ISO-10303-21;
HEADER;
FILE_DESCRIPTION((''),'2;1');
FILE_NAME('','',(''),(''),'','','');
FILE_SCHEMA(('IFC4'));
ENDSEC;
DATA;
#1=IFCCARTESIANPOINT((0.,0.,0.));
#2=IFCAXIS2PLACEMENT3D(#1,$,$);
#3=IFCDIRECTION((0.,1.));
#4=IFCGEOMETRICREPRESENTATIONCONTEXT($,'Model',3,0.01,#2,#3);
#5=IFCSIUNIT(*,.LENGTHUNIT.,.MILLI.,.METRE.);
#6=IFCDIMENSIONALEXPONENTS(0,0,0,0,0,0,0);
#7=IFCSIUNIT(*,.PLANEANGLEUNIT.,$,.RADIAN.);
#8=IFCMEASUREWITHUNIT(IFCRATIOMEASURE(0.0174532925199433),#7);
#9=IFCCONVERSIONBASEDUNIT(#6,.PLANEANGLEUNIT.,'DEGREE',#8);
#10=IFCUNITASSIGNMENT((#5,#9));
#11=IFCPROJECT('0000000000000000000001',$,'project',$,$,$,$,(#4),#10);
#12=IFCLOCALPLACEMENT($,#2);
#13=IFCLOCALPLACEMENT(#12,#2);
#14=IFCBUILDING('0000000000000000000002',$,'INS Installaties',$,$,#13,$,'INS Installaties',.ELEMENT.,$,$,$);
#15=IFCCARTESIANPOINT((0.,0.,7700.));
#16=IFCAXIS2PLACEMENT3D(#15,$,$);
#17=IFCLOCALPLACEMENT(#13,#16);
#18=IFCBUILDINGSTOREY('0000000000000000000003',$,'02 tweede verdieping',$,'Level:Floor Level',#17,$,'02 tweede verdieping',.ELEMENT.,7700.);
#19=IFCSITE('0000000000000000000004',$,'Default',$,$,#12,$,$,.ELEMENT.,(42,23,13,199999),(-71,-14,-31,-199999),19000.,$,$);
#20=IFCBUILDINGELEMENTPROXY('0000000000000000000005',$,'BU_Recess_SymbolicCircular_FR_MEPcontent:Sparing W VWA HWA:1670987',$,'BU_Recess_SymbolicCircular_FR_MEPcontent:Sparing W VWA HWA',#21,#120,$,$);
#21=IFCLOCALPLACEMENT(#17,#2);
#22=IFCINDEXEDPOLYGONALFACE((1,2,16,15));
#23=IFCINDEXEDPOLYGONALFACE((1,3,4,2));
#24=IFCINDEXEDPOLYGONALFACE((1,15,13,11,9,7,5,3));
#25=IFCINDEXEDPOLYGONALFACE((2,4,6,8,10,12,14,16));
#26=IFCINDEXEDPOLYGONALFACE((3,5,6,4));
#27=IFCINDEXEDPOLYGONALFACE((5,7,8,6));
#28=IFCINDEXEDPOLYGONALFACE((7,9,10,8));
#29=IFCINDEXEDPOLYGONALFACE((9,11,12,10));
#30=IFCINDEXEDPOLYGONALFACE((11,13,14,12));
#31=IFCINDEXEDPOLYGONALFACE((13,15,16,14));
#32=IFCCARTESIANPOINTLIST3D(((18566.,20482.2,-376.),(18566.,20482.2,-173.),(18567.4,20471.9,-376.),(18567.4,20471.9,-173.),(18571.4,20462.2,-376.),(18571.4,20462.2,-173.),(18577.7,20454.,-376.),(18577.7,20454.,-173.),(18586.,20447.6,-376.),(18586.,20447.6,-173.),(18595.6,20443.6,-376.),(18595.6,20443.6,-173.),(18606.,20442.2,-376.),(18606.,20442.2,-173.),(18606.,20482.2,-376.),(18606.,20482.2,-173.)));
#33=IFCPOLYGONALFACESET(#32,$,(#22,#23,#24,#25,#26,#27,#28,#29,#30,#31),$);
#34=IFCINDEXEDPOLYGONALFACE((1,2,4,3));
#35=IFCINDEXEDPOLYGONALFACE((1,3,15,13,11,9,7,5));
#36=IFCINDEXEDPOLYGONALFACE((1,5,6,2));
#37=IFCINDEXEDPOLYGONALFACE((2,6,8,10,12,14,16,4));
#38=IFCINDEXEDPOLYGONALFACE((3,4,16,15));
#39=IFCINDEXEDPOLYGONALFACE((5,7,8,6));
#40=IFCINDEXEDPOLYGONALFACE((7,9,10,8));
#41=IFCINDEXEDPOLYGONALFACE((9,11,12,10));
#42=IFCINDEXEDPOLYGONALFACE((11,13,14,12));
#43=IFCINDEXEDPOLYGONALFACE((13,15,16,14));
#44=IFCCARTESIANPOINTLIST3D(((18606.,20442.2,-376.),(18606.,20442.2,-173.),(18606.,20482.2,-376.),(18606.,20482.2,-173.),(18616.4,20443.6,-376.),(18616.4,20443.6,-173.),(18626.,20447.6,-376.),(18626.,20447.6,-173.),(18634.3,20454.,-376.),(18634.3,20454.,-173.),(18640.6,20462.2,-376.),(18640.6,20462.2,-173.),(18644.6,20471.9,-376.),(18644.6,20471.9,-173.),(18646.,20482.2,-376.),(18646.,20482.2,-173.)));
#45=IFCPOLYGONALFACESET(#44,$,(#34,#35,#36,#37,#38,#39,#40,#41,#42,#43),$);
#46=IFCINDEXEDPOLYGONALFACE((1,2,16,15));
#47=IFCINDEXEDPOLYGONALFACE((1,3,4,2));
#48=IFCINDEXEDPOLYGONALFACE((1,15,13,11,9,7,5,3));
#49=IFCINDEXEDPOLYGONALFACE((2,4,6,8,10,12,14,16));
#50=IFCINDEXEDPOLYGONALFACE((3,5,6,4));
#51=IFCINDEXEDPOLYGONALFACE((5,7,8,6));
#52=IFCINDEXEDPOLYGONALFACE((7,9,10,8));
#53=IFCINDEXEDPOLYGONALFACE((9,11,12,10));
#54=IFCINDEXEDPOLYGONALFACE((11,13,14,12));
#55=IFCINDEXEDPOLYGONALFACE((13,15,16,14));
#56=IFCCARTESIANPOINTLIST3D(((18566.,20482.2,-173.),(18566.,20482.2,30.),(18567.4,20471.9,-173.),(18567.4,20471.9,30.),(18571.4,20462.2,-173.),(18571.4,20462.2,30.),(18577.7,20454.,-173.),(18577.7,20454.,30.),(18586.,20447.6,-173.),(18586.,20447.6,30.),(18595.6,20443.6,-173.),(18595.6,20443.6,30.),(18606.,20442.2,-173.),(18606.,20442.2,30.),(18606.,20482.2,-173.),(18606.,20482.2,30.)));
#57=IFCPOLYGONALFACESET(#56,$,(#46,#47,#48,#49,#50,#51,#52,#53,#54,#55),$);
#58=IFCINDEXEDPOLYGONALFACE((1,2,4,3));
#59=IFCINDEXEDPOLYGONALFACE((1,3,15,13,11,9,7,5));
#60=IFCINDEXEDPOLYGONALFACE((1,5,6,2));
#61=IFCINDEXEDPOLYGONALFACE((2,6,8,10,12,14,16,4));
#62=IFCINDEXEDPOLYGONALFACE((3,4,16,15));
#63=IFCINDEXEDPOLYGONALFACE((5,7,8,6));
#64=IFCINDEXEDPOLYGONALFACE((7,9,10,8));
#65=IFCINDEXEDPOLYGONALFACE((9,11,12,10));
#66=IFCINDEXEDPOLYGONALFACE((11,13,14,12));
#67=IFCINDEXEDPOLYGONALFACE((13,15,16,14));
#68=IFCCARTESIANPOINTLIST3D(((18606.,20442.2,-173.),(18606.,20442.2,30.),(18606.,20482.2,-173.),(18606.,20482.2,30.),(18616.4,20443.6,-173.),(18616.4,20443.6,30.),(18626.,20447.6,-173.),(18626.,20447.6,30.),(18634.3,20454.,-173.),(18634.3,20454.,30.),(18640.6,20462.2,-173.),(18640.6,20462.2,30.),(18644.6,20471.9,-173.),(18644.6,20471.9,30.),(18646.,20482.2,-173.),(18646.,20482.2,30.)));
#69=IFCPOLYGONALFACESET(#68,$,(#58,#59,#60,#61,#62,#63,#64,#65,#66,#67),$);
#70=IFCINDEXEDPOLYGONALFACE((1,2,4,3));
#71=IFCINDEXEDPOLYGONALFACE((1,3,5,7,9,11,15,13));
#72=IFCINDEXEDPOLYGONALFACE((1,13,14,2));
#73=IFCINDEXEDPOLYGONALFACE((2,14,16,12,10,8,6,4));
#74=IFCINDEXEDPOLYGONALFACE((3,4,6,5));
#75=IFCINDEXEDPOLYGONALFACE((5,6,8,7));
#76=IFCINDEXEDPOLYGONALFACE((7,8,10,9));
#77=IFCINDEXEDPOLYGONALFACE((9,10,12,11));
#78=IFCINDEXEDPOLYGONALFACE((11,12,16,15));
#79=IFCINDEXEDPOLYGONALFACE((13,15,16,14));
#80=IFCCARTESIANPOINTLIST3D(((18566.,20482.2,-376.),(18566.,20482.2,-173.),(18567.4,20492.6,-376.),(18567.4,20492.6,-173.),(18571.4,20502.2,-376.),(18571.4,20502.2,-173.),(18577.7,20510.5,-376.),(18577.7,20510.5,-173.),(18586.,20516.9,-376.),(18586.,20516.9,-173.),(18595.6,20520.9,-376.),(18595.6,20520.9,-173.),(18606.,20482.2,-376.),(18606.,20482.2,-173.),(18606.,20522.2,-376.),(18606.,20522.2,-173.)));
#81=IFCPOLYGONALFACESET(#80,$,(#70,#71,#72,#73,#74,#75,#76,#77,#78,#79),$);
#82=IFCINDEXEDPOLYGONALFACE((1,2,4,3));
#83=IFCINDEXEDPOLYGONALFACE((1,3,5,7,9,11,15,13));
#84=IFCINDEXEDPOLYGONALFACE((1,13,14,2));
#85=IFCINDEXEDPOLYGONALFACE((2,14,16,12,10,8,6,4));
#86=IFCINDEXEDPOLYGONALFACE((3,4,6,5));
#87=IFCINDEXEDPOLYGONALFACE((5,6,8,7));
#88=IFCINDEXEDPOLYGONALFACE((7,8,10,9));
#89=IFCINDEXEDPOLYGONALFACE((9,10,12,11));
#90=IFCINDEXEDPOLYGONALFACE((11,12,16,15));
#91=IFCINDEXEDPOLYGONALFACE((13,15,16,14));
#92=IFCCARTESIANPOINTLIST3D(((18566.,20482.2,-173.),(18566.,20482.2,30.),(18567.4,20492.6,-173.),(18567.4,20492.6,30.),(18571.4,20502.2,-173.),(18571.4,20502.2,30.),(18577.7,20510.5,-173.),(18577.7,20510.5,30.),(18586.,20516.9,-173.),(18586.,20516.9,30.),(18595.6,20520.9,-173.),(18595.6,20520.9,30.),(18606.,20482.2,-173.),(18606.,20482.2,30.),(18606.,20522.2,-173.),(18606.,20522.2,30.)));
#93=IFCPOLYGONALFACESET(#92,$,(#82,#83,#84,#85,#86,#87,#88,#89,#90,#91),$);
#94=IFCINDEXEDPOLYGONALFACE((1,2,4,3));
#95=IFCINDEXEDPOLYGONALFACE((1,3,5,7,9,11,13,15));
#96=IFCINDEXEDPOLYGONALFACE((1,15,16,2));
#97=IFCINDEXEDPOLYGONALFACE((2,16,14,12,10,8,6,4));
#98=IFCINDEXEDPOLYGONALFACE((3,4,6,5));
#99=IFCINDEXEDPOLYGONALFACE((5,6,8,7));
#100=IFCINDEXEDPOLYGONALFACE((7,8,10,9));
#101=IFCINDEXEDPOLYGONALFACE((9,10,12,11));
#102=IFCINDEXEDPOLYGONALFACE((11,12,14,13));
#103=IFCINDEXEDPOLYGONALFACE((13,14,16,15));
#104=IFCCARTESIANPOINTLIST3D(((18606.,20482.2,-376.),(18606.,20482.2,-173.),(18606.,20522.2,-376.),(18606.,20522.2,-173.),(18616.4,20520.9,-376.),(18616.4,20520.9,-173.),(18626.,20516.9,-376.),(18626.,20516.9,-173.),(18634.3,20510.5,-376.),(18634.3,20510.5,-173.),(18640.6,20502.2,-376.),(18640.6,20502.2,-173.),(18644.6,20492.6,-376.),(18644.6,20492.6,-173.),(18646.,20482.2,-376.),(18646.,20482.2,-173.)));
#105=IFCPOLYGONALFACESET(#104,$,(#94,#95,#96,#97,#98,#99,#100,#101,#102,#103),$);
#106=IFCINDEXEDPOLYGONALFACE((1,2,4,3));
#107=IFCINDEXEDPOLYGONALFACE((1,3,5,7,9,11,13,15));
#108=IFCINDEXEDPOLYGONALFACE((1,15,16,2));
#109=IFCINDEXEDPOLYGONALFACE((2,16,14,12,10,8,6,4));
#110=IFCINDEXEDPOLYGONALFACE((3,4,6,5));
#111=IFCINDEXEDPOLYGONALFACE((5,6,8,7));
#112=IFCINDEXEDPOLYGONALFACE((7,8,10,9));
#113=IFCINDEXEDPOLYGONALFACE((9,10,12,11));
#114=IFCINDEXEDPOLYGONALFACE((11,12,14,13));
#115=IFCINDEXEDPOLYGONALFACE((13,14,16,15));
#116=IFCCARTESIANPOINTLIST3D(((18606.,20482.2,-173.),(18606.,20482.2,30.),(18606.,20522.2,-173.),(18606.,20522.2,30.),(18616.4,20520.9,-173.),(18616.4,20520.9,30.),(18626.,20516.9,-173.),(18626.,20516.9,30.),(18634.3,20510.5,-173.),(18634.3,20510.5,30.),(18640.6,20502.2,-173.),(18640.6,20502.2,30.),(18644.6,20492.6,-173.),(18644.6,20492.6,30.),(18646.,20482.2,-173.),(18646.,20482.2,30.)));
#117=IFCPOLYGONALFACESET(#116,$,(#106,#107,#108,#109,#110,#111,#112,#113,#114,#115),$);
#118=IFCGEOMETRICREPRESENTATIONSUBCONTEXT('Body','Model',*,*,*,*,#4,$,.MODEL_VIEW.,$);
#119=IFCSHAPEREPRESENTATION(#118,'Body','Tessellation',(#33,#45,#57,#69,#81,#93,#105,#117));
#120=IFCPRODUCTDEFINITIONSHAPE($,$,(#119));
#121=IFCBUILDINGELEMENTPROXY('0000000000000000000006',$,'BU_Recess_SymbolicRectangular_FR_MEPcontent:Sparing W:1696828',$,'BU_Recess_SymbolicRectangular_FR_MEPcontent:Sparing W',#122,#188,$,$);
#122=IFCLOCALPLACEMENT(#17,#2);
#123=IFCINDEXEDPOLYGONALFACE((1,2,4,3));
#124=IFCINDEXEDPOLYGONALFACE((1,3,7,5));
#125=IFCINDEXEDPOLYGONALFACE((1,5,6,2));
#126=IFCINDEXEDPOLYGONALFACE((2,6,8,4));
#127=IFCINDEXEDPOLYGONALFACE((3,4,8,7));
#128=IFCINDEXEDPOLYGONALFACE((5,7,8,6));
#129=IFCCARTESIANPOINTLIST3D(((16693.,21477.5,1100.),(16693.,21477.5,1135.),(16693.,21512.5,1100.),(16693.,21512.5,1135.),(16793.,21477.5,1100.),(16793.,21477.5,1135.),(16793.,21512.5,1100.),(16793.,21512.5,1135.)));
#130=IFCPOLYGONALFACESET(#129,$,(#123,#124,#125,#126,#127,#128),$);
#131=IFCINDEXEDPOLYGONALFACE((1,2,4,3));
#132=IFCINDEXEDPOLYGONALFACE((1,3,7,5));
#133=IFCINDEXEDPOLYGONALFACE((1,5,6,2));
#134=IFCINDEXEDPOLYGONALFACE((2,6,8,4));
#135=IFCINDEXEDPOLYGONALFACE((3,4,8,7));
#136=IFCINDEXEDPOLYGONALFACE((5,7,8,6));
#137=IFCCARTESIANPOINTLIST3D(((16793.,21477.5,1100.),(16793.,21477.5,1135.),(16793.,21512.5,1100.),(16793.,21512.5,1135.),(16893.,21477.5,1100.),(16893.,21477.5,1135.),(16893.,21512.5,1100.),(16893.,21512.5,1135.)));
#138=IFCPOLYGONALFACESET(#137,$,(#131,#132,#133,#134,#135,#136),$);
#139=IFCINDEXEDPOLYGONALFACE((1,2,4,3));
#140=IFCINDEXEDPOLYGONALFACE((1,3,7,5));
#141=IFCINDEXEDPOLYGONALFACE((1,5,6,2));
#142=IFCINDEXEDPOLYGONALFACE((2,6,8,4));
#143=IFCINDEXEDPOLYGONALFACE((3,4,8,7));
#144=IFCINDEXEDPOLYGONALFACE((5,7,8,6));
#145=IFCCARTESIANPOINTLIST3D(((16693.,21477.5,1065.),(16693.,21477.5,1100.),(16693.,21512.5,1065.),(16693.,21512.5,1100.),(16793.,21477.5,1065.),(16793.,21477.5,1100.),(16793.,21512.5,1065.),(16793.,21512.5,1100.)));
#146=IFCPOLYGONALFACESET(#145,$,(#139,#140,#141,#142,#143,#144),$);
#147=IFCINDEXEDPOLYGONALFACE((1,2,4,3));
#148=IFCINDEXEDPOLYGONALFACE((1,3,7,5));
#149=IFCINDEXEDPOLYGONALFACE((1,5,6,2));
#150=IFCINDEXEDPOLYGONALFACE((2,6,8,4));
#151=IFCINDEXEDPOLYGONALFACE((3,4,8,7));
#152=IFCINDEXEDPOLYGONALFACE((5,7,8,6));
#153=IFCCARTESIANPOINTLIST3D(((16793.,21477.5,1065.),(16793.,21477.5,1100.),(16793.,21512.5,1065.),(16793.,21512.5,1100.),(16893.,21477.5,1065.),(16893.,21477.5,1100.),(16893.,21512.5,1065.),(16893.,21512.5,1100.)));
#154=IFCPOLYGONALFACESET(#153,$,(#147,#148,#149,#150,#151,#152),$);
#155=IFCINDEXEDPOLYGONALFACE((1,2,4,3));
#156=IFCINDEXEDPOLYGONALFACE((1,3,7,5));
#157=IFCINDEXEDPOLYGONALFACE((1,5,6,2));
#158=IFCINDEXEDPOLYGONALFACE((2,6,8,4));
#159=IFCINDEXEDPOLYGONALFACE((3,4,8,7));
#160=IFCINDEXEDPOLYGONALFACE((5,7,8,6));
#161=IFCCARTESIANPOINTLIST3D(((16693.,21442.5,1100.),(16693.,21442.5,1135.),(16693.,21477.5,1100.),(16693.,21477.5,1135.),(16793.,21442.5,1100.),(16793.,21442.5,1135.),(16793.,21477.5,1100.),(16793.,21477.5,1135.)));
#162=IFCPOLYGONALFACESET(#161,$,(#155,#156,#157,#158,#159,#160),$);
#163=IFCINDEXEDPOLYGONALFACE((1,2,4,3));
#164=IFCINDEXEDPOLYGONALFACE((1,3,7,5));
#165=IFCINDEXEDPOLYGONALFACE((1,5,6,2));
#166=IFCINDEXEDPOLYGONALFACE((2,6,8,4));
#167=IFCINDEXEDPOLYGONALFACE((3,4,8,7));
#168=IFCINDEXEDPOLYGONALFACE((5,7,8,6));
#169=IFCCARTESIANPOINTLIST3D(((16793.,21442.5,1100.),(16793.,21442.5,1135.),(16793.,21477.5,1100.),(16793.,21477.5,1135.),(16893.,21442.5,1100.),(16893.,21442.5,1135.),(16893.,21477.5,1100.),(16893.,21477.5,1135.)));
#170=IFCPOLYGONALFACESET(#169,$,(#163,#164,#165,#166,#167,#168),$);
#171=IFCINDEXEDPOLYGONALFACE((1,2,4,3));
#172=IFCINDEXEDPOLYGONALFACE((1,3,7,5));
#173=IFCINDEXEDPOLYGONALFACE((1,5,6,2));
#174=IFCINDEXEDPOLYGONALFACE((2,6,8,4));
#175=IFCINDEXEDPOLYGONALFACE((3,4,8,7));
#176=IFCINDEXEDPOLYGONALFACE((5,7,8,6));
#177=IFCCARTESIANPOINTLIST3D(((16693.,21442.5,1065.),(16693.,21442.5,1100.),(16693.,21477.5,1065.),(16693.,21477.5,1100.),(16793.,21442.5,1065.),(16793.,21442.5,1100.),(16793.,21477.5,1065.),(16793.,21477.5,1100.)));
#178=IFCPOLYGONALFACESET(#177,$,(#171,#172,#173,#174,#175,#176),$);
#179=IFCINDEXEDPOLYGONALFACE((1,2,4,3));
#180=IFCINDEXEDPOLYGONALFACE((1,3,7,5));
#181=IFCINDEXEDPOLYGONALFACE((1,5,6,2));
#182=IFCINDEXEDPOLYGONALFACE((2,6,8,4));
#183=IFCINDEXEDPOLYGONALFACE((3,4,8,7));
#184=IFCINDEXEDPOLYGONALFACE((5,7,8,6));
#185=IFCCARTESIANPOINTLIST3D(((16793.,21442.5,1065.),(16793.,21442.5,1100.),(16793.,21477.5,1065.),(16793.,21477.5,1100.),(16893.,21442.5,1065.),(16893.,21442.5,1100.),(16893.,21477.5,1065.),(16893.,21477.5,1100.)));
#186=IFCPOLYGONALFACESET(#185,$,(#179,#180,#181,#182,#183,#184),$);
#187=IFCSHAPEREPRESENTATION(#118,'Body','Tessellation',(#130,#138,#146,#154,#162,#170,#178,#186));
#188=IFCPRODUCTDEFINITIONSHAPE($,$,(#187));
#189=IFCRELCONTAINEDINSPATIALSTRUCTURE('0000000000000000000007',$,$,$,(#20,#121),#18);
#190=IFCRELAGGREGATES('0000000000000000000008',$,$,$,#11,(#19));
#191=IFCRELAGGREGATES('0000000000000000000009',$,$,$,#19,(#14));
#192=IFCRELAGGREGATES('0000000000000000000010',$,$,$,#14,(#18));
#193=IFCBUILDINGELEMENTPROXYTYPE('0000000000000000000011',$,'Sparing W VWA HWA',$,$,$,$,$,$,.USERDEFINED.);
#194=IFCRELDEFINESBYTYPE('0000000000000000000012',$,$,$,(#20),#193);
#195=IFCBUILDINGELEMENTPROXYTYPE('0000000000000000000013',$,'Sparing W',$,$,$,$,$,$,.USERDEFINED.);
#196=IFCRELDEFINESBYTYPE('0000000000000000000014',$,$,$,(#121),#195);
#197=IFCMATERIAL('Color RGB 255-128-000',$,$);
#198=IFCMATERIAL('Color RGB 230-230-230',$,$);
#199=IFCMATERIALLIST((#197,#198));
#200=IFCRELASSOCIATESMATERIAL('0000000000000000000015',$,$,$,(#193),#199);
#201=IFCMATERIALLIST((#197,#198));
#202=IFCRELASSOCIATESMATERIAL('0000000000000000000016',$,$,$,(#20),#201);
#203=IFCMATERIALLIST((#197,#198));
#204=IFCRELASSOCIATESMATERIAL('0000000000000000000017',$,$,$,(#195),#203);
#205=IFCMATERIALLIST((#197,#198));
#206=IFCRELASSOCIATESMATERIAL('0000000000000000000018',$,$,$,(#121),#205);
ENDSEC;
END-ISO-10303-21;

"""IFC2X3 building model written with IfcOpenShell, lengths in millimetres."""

from ifc_helpers import new_model, entity, si_unit, converted_unit, direction, frame, frame_2d, origin, place, context, subcontext, project, spatial, polyline, circle_curve, parameter, trimmed, segment, composite_curve, rectangle, outline, extrude, source, transform, mapped, material, material_list, type_object, type_shapes, element, save


model = new_model("IFC2X3")

# Units and contexts
model_context = context("Model", 3, precision=0.01, world=origin(), true_north=direction((0.0, 1.0)))
body_context = subcontext(model_context, "Body", "Model", "MODEL_VIEW")
ifc_project = project(units=[si_unit("LENGTHUNIT", "METRE", prefix="MILLI"), converted_unit("PLANEANGLEUNIT", "DEGREE", entity("IfcRatioMeasure", 0.0174532925199433), si_unit("PLANEANGLEUNIT", "RADIAN"), dimensions=[0, 0, 0, 0, 0, 0, 0])], contexts=[model_context])

# Site, building, storey
site_placement = place(None, origin())
site = spatial("IfcSite", under=ifc_project, at=site_placement, Name="Default", CompositionType="ELEMENT", RefLatitude=(42, 23, 13, 199999), RefLongitude=(-71, -14, -31, -199999), RefElevation=19000.0)
building_placement = place(site_placement, origin())
building = spatial("IfcBuilding", under=site, at=building_placement, Name="INS Installaties", LongName="INS Installaties", CompositionType="ELEMENT")
storey_placement = place(building_placement, frame((0.0, 0.0, 7700.0)))
storey = spatial("IfcBuildingStorey", under=building, at=storey_placement, Name="02 tweede verdieping", ObjectType="Level:Floor Level", LongName="02 tweede verdieping", CompositionType="ELEMENT", Elevation=7700.0)

# Building element proxies
ifc_material_1 = material(Name="Color RGB 255-128-000")
ifc_material_2 = material(Name="Color RGB 230-230-230")
ifc_material_list_1 = material_list([ifc_material_1, ifc_material_2])
building_element_proxy_type_1 = type_object("IfcBuildingElementProxyType", Name="Sparing W VWA HWA", PredefinedType="USERDEFINED", material=ifc_material_list_1)
shared_shape_1 = source(origin(), body_context, "Body", "SweptSolid", [
    extrude(outline(composite_curve([segment(trimmed(circle_curve(frame_2d((13.3, 13.3), x_axis=(1.0, 0.0)), 40.0), [parameter(180.0)], [parameter(270.0)], True, "PARAMETER"), True, "CONTINUOUS"), segment(polyline([(13.3, -26.7), (13.3, 13.3)]), True, "CONTINUOUS"), segment(polyline([(13.3, 13.3), (-26.7, 13.3)]), True, "CONTINUOUS")], self_intersect=False)), frame((13.3, 13.3, -403.0), z_axis=(0.0, 0.0, 1.0), x_axis=(-1.0, 0.0, 0.0)), (0.0, 0.0, 1.0), 203.0),
    extrude(outline(composite_curve([segment(polyline([(-26.7, -13.3), (13.3, -13.3)]), True, "CONTINUOUS"), segment(polyline([(13.3, -13.3), (13.3, 26.7)]), True, "CONTINUOUS"), segment(trimmed(circle_curve(frame_2d((13.3, -13.3), x_axis=(1.0, 0.0)), 40.0), [parameter(90.0)], [parameter(180.0)], True, "PARAMETER"), True, "CONTINUOUS")], self_intersect=False)), frame((-13.3, 13.3, -403.0)), (0.0, 0.0, 1.0), 203.0),
    extrude(outline(composite_curve([segment(trimmed(circle_curve(frame_2d((13.3, 13.3), x_axis=(1.0, 0.0)), 40.0), [parameter(180.0)], [parameter(270.0)], True, "PARAMETER"), True, "CONTINUOUS"), segment(polyline([(13.3, -26.7), (13.3, 13.3)]), True, "CONTINUOUS"), segment(polyline([(13.3, 13.3), (-26.7, 13.3)]), True, "CONTINUOUS")], self_intersect=False)), frame((13.3, 13.3, -200.0), z_axis=(0.0, 0.0, 1.0), x_axis=(-1.0, 0.0, 0.0)), (0.0, 0.0, 1.0), 203.0),
    extrude(outline(composite_curve([segment(polyline([(-26.7, -13.3), (13.3, -13.3)]), True, "CONTINUOUS"), segment(polyline([(13.3, -13.3), (13.3, 26.7)]), True, "CONTINUOUS"), segment(trimmed(circle_curve(frame_2d((13.3, -13.3), x_axis=(1.0, 0.0)), 40.0), [parameter(90.0)], [parameter(180.0)], True, "PARAMETER"), True, "CONTINUOUS")], self_intersect=False)), frame((-13.3, 13.3, -200.0)), (0.0, 0.0, 1.0), 203.0),
    extrude(outline(composite_curve([segment(polyline([(-26.7, -13.3), (13.3, -13.3)]), True, "CONTINUOUS"), segment(polyline([(13.3, -13.3), (13.3, 26.7)]), True, "CONTINUOUS"), segment(trimmed(circle_curve(frame_2d((13.3, -13.3), x_axis=(1.0, 0.0)), 40.0), [parameter(90.0)], [parameter(180.0)], True, "PARAMETER"), True, "CONTINUOUS")], self_intersect=False)), frame((13.3, -13.3, -403.0), z_axis=(0.0, 0.0, 1.0), x_axis=(-1.0, 0.0, 0.0)), (0.0, 0.0, 1.0), 203.0),
    extrude(outline(composite_curve([segment(polyline([(-26.7, -13.3), (13.3, -13.3)]), True, "CONTINUOUS"), segment(polyline([(13.3, -13.3), (13.3, 26.7)]), True, "CONTINUOUS"), segment(trimmed(circle_curve(frame_2d((13.3, -13.3), x_axis=(1.0, 0.0)), 40.0), [parameter(90.0)], [parameter(180.0)], True, "PARAMETER"), True, "CONTINUOUS")], self_intersect=False)), frame((13.3, -13.3, -200.0), z_axis=(0.0, 0.0, 1.0), x_axis=(-1.0, 0.0, 0.0)), (0.0, 0.0, 1.0), 203.0),
    extrude(outline(composite_curve([segment(trimmed(circle_curve(frame_2d((13.3, 13.3), x_axis=(1.0, 0.0)), 40.0), [parameter(180.0)], [parameter(270.0)], True, "PARAMETER"), True, "CONTINUOUS"), segment(polyline([(13.3, -26.7), (13.3, 13.3)]), True, "CONTINUOUS"), segment(polyline([(13.3, 13.3), (-26.7, 13.3)]), True, "CONTINUOUS")], self_intersect=False)), frame((-13.3, -13.3, -403.0)), (0.0, 0.0, 1.0), 203.0),
    extrude(outline(composite_curve([segment(trimmed(circle_curve(frame_2d((13.3, 13.3), x_axis=(1.0, 0.0)), 40.0), [parameter(180.0)], [parameter(270.0)], True, "PARAMETER"), True, "CONTINUOUS"), segment(polyline([(13.3, -26.7), (13.3, 13.3)]), True, "CONTINUOUS"), segment(polyline([(13.3, 13.3), (-26.7, 13.3)]), True, "CONTINUOUS")], self_intersect=False)), frame((-13.3, -13.3, -200.0)), (0.0, 0.0, 1.0), 203.0),
])
type_shapes(building_element_proxy_type_1, [shared_shape_1])
ifc_material_list_2 = material_list([ifc_material_1, ifc_material_2])
proxy_1_placement = place(storey_placement, frame((18606.0, 20482.2, 27.0), z_axis=(0.0, 0.0, 1.0), x_axis=(-1.0, 0.0, 0.0)))
element("IfcBuildingElementProxy", 1, at=proxy_1_placement, inside=storey, type_object=building_element_proxy_type_1, material=ifc_material_list_2, Name="BU_Recess_SymbolicCircular_FR_MEPcontent:Sparing W VWA HWA:1670987", ObjectType="BU_Recess_SymbolicCircular_FR_MEPcontent:Sparing W VWA HWA", context=body_context, shape_type="MappedRepresentation", body=[
    mapped(shared_shape_1, transform((0.0, 0.0, 0.0), scale=1.0)),
])
ifc_material_list_3 = material_list([ifc_material_1, ifc_material_2])
ifc_material_list_4 = material_list([ifc_material_1, ifc_material_2])
building_element_proxy_type_2 = type_object("IfcBuildingElementProxyType", Name="Sparing W", PredefinedType="USERDEFINED", material=ifc_material_list_4)
shared_shape_2 = source(origin(), body_context, "Body", "SweptSolid", [
    extrude(rectangle(XDim=35.0, YDim=100.0, at=frame_2d((0.0, 0.0), x_axis=(1.0, 0.0))), frame((50.0, -49.5, 0.0), z_axis=(0.0, 0.0, 1.0), x_axis=(0.0, -1.0, 0.0)), (0.0, 0.0, 1.0), 35.0),
    extrude(rectangle(XDim=35.0, YDim=100.0, at=frame_2d((0.0, 0.0), x_axis=(1.0, 0.0))), frame((-50.0, -49.5, 0.0), z_axis=(0.0, 0.0, 1.0), x_axis=(0.0, -1.0, 0.0)), (0.0, 0.0, 1.0), 35.0),
    extrude(rectangle(XDim=35.0, YDim=100.0, at=frame_2d((0.0, 0.0), x_axis=(1.0, 0.0))), frame((50.0, -49.5, -35.0), z_axis=(0.0, 0.0, 1.0), x_axis=(0.0, -1.0, 0.0)), (0.0, 0.0, 1.0), 35.0),
    extrude(rectangle(XDim=35.0, YDim=100.0, at=frame_2d((0.0, 0.0), x_axis=(1.0, 0.0))), frame((-50.0, -49.5, -35.0), z_axis=(0.0, 0.0, 1.0), x_axis=(0.0, -1.0, 0.0)), (0.0, 0.0, 1.0), 35.0),
    extrude(rectangle(XDim=35.0, YDim=100.0, at=frame_2d((0.0, 0.0), x_axis=(1.0, 0.0))), frame((50.0, -14.5, 0.0), z_axis=(0.0, 0.0, 1.0), x_axis=(0.0, -1.0, 0.0)), (0.0, 0.0, 1.0), 35.0),
    extrude(rectangle(XDim=35.0, YDim=100.0, at=frame_2d((0.0, 0.0), x_axis=(1.0, 0.0))), frame((-50.0, -14.5, 0.0), z_axis=(0.0, 0.0, 1.0), x_axis=(0.0, -1.0, 0.0)), (0.0, 0.0, 1.0), 35.0),
    extrude(rectangle(XDim=35.0, YDim=100.0, at=frame_2d((0.0, 0.0), x_axis=(1.0, 0.0))), frame((50.0, -14.5, -35.0), z_axis=(0.0, 0.0, 1.0), x_axis=(0.0, -1.0, 0.0)), (0.0, 0.0, 1.0), 35.0),
    extrude(rectangle(XDim=35.0, YDim=100.0, at=frame_2d((0.0, 0.0), x_axis=(1.0, 0.0))), frame((-50.0, -14.5, -35.0), z_axis=(0.0, 0.0, 1.0), x_axis=(0.0, -1.0, 0.0)), (0.0, 0.0, 1.0), 35.0),
])
type_shapes(building_element_proxy_type_2, [shared_shape_2])
proxy_2_placement = place(storey_placement, frame((16793.0, 21445.5, 1100.0), z_axis=(0.0, 0.0, 1.0), x_axis=(-1.0, 0.0, 0.0)))
element("IfcBuildingElementProxy", 2, at=proxy_2_placement, inside=storey, type_object=building_element_proxy_type_2, material=ifc_material_list_3, Name="BU_Recess_SymbolicRectangular_FR_MEPcontent:Sparing W:1696828", ObjectType="BU_Recess_SymbolicRectangular_FR_MEPcontent:Sparing W", context=body_context, shape_type="MappedRepresentation", body=[
    mapped(shared_shape_2, transform((0.0, 0.0, 0.0), scale=1.0)),
])

save(model, "model.ifc")
